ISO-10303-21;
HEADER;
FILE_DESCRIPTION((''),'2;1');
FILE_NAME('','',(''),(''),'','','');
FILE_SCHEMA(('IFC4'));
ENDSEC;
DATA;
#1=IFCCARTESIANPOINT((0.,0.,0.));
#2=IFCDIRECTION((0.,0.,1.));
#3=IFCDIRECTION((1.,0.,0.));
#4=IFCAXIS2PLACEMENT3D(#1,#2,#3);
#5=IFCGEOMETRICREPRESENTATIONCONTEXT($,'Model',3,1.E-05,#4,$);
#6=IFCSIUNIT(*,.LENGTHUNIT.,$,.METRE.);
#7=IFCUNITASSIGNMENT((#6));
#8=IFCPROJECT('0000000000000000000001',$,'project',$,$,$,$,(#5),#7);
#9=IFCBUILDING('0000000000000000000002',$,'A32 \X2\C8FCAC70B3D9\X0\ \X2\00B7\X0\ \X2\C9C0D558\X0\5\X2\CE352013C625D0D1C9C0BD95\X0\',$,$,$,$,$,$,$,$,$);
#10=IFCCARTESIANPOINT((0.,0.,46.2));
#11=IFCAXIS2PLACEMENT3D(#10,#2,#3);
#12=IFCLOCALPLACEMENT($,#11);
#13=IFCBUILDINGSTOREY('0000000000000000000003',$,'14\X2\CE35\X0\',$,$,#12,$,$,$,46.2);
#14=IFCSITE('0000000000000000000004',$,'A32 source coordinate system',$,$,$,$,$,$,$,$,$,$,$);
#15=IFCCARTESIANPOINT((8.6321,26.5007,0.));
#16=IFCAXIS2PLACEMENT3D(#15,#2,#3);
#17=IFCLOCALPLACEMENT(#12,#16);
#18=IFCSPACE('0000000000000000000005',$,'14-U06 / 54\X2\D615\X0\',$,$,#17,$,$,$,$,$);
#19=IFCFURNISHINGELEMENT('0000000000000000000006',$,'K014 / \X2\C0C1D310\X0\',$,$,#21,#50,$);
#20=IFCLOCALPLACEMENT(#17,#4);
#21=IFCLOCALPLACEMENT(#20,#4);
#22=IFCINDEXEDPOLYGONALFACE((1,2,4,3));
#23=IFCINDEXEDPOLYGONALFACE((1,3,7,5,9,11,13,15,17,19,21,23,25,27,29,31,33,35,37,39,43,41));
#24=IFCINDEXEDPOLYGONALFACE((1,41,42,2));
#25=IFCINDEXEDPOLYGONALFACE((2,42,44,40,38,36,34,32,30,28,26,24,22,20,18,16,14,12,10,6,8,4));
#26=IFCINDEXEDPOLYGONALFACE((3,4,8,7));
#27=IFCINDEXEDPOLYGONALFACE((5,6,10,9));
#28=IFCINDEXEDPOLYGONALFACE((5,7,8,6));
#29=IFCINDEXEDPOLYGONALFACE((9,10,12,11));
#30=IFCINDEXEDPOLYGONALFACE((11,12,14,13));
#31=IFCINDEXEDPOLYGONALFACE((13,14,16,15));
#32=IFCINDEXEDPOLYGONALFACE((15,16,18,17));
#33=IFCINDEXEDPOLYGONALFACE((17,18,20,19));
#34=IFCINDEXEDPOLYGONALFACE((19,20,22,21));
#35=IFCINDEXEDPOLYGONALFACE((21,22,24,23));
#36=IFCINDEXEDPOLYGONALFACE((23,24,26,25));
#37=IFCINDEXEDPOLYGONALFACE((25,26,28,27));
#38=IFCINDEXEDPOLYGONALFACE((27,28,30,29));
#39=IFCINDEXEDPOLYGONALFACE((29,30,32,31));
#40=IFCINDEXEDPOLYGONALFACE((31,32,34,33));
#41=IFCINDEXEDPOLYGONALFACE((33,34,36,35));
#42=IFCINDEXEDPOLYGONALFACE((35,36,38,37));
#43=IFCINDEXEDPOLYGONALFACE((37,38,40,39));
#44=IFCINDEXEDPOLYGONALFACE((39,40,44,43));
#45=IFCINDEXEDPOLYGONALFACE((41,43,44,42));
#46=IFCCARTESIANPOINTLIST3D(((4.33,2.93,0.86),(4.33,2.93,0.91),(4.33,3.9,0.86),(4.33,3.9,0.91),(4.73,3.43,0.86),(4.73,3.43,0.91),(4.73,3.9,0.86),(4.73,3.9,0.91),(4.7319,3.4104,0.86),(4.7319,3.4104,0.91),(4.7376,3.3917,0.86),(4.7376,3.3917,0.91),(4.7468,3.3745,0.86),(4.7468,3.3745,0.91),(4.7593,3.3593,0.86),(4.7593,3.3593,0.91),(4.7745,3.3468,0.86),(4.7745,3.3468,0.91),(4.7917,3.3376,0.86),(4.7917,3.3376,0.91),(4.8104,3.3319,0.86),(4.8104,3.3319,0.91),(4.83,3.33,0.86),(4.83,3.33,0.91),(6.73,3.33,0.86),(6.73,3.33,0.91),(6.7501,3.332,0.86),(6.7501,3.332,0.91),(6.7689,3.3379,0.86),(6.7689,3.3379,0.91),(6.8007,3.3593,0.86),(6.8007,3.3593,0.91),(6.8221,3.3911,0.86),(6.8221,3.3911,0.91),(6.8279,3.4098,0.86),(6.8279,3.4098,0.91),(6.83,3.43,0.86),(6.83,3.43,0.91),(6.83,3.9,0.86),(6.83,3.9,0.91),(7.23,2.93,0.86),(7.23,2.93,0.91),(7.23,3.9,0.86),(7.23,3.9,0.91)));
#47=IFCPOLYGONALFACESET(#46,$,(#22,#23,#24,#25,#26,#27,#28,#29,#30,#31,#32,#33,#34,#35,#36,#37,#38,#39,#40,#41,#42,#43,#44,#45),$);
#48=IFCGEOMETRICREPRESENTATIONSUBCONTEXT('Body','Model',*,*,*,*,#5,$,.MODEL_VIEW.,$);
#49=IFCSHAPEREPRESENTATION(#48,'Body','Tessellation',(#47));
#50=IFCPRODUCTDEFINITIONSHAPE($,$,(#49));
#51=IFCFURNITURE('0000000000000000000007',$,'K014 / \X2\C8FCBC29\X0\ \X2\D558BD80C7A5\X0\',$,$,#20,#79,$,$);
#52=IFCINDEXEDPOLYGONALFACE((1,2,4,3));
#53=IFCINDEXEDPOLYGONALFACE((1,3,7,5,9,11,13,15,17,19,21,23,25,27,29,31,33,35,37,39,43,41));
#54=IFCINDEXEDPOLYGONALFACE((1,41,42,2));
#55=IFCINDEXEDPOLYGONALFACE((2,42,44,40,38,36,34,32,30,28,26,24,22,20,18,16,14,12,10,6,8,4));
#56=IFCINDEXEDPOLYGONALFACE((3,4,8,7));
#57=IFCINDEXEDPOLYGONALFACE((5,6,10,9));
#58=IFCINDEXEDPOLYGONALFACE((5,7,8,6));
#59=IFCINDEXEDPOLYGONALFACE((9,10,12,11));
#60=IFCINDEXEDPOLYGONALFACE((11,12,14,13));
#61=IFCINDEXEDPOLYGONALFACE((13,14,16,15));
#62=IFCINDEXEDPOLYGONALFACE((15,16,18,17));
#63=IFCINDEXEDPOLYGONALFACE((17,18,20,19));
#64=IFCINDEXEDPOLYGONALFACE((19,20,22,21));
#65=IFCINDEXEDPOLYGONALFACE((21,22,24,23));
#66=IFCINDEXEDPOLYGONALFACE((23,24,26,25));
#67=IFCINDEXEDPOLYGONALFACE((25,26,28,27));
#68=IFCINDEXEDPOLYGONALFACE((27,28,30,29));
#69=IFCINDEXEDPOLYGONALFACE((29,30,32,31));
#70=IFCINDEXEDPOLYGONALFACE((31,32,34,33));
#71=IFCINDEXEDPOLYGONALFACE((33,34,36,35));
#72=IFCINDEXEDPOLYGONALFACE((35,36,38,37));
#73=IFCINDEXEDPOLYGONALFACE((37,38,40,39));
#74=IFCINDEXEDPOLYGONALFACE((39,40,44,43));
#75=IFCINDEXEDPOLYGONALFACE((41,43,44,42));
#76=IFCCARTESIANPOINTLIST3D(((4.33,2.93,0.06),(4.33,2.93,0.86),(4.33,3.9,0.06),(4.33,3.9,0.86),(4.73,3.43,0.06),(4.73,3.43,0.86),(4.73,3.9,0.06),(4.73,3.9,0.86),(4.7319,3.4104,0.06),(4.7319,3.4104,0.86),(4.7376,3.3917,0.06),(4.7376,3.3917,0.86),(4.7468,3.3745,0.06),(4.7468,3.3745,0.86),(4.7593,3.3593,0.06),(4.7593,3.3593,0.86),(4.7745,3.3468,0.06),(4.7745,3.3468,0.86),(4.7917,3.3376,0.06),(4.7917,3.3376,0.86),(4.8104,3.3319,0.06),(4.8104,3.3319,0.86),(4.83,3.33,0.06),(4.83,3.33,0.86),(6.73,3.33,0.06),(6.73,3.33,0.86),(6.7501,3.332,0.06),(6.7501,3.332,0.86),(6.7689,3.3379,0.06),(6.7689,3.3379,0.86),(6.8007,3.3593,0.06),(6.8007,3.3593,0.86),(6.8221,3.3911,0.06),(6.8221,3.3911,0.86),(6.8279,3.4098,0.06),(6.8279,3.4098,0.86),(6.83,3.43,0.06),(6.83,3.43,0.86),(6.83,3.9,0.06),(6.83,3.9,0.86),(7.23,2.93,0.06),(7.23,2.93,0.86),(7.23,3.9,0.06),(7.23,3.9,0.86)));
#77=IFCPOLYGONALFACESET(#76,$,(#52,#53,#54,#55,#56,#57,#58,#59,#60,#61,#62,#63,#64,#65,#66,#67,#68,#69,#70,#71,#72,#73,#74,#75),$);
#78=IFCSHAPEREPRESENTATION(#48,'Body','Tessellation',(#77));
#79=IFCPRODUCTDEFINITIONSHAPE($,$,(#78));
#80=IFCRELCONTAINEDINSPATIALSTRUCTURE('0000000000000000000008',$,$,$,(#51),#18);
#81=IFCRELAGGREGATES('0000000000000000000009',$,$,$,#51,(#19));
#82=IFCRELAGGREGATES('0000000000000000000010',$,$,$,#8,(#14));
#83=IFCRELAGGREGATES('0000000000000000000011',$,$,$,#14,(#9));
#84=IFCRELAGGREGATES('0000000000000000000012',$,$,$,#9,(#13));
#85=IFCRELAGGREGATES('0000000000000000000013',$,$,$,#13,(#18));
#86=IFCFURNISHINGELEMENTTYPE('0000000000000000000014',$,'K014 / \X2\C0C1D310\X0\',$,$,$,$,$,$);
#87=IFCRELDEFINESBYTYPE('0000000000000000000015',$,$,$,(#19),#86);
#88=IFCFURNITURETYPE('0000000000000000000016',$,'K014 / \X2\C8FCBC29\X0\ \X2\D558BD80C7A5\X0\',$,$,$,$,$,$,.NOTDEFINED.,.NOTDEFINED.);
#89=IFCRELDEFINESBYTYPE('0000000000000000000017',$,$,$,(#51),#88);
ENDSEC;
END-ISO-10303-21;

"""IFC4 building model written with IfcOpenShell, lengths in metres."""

from ifc_helpers import new_model, si_unit, frame, origin, origin_with_axes, place, context, subcontext, project, spatial, polyline, outline, extrude, source, transform, mapped, type_object, type_shapes, element, aggregate, save


model = new_model("IFC4")

# Units and contexts
model_context = context("Model", 3, precision=1e-05, world=origin_with_axes())
body_context = subcontext(model_context, "Body", "Model", "MODEL_VIEW")
ifc_project = project(units=[si_unit("LENGTHUNIT", "METRE")], contexts=[model_context])

# Site, building, storey, space
site = spatial("IfcSite", under=ifc_project, Name="A32 source coordinate system")
building = spatial("IfcBuilding", under=site, Name="A32 주거동 · 지하5층–옥탑지붕")
storey_placement = place(None, frame((0.0, 0.0, 46.2), z_axis=(0.0, 0.0, 1.0), x_axis=(1.0, 0.0, 0.0)))
storey = spatial("IfcBuildingStorey", under=building, at=storey_placement, Name="14층", Elevation=46.2)
space_placement = place(storey_placement, frame((8.6321, 26.5007, 0.0), z_axis=(0.0, 0.0, 1.0), x_axis=(1.0, 0.0, 0.0)))
space = spatial("IfcSpace", under=storey, at=space_placement, Name="14-U06 / 54형")

# Furnishing element
furnishing_element_type_1 = type_object("IfcFurnishingElementType", Name="K014 / 상판")
shared_shape_1 = source(origin(), body_context, "Body", "SweptSolid", [
    extrude(outline(polyline([(4.33, 2.93), (4.33, 3.9), (4.73, 3.9), (4.73, 3.43), (4.7319, 3.4104), (4.7376, 3.3917), (4.7468, 3.3745), (4.7593, 3.3593), (4.7745, 3.3468), (4.7917, 3.3376), (4.8104, 3.3319), (4.83, 3.33), (6.73, 3.33), (6.7501, 3.332), (6.7689, 3.3379), (6.8007, 3.3593), (6.8221, 3.3911), (6.8279, 3.4098), (6.83, 3.43), (6.83, 3.9), (7.23, 3.9), (7.23, 2.93), (4.33, 2.93)])), frame((0.0, 0.0, 0.86)), (0.0, 0.0, 1.0), 0.05),
])
type_shapes(furnishing_element_type_1, [shared_shape_1])
furniture_1_placement = place(space_placement, origin_with_axes())
furnishing_1_placement = place(furniture_1_placement, origin_with_axes())
furnishing_1 = element("IfcFurnishingElement", 1, at=furnishing_1_placement, type_object=furnishing_element_type_1, Name="K014 / 상판", context=body_context, shape_type="MappedRepresentation", body=[
    mapped(shared_shape_1, transform((0.0, 0.0, 0.0), scale=1.0)),
])

# Furniture
furniture_type_1 = type_object("IfcFurnitureType", Name="K014 / 주방 하부장", AssemblyPlace="NOTDEFINED", PredefinedType="NOTDEFINED")
shared_shape_2 = source(origin(), body_context, "Body", "SweptSolid", [
    extrude(outline(polyline([(7.23, 2.93), (4.33, 2.93), (4.33, 3.9), (4.73, 3.9), (4.73, 3.43), (4.7319, 3.4104), (4.7376, 3.3917), (4.7468, 3.3745), (4.7593, 3.3593), (4.7745, 3.3468), (4.7917, 3.3376), (4.8104, 3.3319), (4.83, 3.33), (6.73, 3.33), (6.7501, 3.332), (6.7689, 3.3379), (6.8007, 3.3593), (6.8221, 3.3911), (6.8279, 3.4098), (6.83, 3.43), (6.83, 3.9), (7.23, 3.9), (7.23, 2.93)])), frame((0.0, 0.0, 0.06)), (0.0, 0.0, 1.0), 0.8),
])
type_shapes(furniture_type_1, [shared_shape_2])
furniture_1 = element("IfcFurniture", 2, at=furniture_1_placement, inside=space, type_object=furniture_type_1, Name="K014 / 주방 하부장", context=body_context, shape_type="MappedRepresentation", body=[
    mapped(shared_shape_2, transform((0.0, 0.0, 0.0), scale=1.0)),
])
aggregate(furniture_1, [furnishing_1])

save(model, "model.ifc")
